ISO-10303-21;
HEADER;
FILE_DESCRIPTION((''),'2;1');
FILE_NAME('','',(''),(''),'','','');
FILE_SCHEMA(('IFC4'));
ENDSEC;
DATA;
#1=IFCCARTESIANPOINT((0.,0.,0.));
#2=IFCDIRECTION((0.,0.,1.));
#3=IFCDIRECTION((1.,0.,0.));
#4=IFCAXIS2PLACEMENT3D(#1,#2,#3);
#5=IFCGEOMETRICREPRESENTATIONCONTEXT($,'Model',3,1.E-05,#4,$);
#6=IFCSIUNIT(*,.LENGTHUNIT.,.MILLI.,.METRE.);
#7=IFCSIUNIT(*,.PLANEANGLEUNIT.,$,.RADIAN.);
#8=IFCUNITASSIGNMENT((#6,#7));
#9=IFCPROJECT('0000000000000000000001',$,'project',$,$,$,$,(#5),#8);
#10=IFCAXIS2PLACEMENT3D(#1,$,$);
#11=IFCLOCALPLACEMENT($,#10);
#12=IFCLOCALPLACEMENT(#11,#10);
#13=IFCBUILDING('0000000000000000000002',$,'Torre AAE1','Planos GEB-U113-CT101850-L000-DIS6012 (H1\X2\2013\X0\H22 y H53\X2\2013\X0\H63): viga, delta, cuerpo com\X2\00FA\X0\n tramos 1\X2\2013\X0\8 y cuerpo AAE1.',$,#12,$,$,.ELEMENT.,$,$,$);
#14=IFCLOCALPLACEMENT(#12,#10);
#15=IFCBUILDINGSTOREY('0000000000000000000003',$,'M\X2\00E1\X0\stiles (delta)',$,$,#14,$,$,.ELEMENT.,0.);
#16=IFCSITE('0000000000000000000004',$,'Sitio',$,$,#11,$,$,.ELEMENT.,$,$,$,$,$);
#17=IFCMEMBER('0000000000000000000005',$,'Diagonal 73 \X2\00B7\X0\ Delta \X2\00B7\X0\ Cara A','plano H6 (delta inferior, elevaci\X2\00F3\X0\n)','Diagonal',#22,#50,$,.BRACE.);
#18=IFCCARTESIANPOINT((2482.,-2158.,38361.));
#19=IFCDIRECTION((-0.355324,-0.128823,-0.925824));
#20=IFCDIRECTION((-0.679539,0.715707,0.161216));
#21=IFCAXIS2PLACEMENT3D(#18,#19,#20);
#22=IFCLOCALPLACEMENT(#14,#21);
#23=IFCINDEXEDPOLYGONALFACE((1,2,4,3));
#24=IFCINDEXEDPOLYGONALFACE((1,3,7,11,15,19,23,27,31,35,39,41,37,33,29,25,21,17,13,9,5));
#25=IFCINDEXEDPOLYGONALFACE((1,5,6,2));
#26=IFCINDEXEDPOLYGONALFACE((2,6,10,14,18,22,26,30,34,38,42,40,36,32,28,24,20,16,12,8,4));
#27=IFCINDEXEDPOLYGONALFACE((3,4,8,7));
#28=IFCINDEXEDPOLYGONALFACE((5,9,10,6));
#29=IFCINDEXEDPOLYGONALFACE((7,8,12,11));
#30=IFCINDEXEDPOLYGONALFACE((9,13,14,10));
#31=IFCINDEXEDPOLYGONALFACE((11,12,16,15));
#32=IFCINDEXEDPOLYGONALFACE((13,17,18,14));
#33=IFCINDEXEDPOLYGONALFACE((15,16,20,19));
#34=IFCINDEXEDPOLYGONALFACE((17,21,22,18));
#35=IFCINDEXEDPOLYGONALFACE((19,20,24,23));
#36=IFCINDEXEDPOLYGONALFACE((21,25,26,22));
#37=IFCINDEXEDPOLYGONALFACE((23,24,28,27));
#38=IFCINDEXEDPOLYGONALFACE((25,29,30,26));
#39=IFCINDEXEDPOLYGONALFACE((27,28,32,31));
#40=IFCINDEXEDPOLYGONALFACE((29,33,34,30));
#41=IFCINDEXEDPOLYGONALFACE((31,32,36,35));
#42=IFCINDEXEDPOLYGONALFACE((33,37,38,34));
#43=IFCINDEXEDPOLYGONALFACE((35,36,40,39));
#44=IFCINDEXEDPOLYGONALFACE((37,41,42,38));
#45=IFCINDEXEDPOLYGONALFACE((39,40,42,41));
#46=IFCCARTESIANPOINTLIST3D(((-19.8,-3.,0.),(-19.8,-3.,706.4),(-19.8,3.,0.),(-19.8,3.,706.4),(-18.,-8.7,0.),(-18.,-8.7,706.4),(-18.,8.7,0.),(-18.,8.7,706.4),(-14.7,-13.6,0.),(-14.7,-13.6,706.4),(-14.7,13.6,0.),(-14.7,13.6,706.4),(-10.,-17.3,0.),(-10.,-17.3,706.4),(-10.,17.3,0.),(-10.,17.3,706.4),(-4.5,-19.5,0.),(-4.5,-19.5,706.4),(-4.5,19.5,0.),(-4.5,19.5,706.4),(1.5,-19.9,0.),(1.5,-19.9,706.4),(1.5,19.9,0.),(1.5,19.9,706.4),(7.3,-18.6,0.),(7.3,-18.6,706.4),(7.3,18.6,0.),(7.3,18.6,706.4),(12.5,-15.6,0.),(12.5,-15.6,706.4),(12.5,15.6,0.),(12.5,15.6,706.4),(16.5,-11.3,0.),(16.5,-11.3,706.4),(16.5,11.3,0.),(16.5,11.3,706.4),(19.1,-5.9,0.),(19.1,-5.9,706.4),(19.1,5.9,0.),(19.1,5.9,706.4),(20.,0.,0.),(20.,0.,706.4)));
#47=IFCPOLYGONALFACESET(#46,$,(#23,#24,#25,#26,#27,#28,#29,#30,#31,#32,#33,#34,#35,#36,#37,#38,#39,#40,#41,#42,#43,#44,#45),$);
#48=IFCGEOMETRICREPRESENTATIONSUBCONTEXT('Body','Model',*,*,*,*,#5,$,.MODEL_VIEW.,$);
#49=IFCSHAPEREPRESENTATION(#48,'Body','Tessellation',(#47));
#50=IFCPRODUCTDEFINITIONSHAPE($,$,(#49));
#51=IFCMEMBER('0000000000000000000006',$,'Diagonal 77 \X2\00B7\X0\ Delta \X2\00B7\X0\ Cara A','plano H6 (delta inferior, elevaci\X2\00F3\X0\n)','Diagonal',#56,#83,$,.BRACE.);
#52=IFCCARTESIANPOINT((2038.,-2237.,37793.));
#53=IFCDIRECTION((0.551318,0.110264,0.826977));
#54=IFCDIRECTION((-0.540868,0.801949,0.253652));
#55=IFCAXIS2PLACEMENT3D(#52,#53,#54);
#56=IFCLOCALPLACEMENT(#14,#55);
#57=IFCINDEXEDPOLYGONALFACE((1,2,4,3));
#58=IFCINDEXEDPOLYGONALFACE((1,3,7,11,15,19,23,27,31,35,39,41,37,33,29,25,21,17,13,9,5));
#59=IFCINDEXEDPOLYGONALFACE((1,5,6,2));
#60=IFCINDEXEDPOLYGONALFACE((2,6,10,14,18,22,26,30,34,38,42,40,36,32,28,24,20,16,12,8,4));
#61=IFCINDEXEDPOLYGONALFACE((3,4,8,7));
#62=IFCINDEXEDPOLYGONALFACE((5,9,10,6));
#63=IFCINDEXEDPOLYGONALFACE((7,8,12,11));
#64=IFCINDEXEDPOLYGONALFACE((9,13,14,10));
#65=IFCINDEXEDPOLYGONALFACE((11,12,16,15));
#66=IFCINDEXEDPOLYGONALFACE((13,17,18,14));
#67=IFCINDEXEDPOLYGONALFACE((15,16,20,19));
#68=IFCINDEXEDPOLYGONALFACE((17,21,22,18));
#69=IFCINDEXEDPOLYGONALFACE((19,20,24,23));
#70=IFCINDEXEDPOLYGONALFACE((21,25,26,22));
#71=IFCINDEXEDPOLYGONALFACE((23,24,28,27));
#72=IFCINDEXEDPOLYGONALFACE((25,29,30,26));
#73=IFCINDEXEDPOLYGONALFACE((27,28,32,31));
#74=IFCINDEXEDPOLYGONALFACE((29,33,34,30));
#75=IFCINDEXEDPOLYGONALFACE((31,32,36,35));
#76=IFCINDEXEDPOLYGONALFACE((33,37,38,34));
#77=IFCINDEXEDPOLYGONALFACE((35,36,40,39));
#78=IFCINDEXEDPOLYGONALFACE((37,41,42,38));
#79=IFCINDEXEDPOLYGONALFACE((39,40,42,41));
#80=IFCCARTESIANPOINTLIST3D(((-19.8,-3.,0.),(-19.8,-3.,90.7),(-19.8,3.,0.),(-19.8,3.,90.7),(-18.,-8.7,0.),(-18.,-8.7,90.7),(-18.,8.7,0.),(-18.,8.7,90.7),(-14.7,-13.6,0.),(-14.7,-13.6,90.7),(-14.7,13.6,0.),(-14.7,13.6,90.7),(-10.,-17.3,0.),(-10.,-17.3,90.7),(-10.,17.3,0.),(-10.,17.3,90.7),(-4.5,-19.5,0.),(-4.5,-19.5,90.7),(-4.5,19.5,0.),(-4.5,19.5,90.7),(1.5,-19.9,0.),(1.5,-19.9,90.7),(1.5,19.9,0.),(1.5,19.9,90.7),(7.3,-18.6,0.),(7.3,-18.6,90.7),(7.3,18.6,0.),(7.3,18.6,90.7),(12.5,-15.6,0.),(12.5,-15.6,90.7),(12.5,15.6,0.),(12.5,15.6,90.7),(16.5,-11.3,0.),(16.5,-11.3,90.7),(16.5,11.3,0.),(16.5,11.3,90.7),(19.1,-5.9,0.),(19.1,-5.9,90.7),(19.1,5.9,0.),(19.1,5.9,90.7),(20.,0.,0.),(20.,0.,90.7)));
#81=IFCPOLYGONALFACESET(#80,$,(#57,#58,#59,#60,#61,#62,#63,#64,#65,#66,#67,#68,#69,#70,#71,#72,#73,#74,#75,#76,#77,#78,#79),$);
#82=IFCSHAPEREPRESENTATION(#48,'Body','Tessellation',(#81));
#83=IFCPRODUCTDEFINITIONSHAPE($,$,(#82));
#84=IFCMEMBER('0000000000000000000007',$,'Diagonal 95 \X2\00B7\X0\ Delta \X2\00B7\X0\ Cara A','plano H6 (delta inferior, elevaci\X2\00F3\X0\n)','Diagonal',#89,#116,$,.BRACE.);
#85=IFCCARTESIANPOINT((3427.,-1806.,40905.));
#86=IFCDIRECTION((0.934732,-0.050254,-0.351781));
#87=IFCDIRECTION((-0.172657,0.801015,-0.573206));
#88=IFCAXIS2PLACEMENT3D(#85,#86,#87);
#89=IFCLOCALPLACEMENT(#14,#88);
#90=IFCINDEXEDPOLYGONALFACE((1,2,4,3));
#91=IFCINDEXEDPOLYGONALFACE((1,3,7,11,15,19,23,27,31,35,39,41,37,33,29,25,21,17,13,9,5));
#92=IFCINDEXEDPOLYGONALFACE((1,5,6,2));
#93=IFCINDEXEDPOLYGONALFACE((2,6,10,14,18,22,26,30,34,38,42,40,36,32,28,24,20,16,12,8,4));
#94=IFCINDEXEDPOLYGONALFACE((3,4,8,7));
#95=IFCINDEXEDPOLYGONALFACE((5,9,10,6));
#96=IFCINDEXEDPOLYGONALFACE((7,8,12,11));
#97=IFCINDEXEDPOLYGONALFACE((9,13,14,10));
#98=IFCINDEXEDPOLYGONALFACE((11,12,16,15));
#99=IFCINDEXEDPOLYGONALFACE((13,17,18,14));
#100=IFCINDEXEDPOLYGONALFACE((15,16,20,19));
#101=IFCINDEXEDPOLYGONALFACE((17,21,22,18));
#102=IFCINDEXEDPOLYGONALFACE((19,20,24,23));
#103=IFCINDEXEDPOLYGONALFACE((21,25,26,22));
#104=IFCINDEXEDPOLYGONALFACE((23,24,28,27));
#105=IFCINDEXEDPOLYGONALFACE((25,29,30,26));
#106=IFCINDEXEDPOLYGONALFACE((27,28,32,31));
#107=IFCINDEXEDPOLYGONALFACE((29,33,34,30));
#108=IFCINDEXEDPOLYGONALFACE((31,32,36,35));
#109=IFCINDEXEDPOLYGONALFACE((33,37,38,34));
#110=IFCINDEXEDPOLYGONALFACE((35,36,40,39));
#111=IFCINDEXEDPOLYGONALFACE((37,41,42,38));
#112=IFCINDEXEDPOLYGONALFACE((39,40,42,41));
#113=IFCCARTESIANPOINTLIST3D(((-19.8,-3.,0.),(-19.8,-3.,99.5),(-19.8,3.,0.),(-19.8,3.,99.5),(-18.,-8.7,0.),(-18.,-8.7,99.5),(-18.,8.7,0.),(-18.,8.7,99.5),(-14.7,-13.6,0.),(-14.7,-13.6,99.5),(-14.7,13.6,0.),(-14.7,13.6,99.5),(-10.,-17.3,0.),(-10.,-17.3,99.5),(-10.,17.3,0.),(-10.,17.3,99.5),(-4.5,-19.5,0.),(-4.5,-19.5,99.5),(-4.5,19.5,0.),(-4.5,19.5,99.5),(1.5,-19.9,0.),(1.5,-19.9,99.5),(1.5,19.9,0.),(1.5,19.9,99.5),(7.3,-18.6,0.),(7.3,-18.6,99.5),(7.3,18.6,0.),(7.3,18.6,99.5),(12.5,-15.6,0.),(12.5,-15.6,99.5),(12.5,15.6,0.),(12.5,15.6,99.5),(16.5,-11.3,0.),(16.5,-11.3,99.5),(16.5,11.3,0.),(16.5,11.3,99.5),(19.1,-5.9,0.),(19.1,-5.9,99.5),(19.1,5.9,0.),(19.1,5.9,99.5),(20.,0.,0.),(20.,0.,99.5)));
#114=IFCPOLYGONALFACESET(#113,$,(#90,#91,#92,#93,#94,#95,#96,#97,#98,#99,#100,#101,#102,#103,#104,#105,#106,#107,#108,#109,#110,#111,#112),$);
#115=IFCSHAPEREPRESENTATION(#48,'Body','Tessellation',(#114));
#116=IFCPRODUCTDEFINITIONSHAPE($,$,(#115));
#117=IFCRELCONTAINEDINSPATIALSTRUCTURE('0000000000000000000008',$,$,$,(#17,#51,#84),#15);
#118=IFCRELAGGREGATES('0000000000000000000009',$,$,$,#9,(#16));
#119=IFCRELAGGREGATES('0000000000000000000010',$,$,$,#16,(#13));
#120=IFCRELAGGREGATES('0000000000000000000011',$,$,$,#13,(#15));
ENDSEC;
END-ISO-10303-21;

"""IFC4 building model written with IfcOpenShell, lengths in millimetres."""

from ifc_helpers import new_model, si_unit, frame, origin, origin_with_axes, place, context, subcontext, project, spatial, circle, extrude, element, save


model = new_model("IFC4")

# Units and contexts
model_context = context("Model", 3, precision=1e-05, world=origin_with_axes())
body_context = subcontext(model_context, "Body", "Model", "MODEL_VIEW")
ifc_project = project(units=[si_unit("LENGTHUNIT", "METRE", prefix="MILLI"), si_unit("PLANEANGLEUNIT", "RADIAN")], contexts=[model_context])

# Site, building, storey
site_placement = place(None, origin())
site = spatial("IfcSite", under=ifc_project, at=site_placement, Name="Sitio", CompositionType="ELEMENT")
building_placement = place(site_placement, origin())
building = spatial("IfcBuilding", under=site, at=building_placement, Name="Torre AAE1", Description="Planos GEB-U113-CT101850-L000-DIS6012 (H1–H22 y H53–H63): viga, delta, cuerpo común tramos 1–8 y cuerpo AAE1.", CompositionType="ELEMENT")
storey_placement = place(building_placement, origin())
storey = spatial("IfcBuildingStorey", under=building, at=storey_placement, Name="Mástiles (delta)", CompositionType="ELEMENT", Elevation=0.0)

# Members
member_1_placement = place(storey_placement, frame((2482.0, -2158.0, 38361.0), z_axis=(-0.355324, -0.128823, -0.925824), x_axis=(-0.679539, 0.715707, 0.161216)))
element("IfcMember", 1, at=member_1_placement, inside=storey, Name="Diagonal 73 · Delta · Cara A", Description="plano H6 (delta inferior, elevación)", ObjectType="Diagonal", PredefinedType="BRACE", context=body_context, shape_type="SweptSolid", body=[
    extrude(circle(Radius=20.0), None, (0.0, 0.0, 1.0), 706.4),
])
member_2_placement = place(storey_placement, frame((2038.0, -2237.0, 37793.0), z_axis=(0.551318, 0.110264, 0.826977), x_axis=(-0.540868, 0.801949, 0.253652)))
element("IfcMember", 2, at=member_2_placement, inside=storey, Name="Diagonal 77 · Delta · Cara A", Description="plano H6 (delta inferior, elevación)", ObjectType="Diagonal", PredefinedType="BRACE", context=body_context, shape_type="SweptSolid", body=[
    extrude(circle(Radius=20.0), None, (0.0, 0.0, 1.0), 90.7),
])
member_3_placement = place(storey_placement, frame((3427.0, -1806.0, 40905.0), z_axis=(0.934732, -0.050254, -0.351781), x_axis=(-0.172657, 0.801015, -0.573206)))
element("IfcMember", 3, at=member_3_placement, inside=storey, Name="Diagonal 95 · Delta · Cara A", Description="plano H6 (delta inferior, elevación)", ObjectType="Diagonal", PredefinedType="BRACE", context=body_context, shape_type="SweptSolid", body=[
    extrude(circle(Radius=20.0), None, (0.0, 0.0, 1.0), 99.5),
])

save(model, "model.ifc")
